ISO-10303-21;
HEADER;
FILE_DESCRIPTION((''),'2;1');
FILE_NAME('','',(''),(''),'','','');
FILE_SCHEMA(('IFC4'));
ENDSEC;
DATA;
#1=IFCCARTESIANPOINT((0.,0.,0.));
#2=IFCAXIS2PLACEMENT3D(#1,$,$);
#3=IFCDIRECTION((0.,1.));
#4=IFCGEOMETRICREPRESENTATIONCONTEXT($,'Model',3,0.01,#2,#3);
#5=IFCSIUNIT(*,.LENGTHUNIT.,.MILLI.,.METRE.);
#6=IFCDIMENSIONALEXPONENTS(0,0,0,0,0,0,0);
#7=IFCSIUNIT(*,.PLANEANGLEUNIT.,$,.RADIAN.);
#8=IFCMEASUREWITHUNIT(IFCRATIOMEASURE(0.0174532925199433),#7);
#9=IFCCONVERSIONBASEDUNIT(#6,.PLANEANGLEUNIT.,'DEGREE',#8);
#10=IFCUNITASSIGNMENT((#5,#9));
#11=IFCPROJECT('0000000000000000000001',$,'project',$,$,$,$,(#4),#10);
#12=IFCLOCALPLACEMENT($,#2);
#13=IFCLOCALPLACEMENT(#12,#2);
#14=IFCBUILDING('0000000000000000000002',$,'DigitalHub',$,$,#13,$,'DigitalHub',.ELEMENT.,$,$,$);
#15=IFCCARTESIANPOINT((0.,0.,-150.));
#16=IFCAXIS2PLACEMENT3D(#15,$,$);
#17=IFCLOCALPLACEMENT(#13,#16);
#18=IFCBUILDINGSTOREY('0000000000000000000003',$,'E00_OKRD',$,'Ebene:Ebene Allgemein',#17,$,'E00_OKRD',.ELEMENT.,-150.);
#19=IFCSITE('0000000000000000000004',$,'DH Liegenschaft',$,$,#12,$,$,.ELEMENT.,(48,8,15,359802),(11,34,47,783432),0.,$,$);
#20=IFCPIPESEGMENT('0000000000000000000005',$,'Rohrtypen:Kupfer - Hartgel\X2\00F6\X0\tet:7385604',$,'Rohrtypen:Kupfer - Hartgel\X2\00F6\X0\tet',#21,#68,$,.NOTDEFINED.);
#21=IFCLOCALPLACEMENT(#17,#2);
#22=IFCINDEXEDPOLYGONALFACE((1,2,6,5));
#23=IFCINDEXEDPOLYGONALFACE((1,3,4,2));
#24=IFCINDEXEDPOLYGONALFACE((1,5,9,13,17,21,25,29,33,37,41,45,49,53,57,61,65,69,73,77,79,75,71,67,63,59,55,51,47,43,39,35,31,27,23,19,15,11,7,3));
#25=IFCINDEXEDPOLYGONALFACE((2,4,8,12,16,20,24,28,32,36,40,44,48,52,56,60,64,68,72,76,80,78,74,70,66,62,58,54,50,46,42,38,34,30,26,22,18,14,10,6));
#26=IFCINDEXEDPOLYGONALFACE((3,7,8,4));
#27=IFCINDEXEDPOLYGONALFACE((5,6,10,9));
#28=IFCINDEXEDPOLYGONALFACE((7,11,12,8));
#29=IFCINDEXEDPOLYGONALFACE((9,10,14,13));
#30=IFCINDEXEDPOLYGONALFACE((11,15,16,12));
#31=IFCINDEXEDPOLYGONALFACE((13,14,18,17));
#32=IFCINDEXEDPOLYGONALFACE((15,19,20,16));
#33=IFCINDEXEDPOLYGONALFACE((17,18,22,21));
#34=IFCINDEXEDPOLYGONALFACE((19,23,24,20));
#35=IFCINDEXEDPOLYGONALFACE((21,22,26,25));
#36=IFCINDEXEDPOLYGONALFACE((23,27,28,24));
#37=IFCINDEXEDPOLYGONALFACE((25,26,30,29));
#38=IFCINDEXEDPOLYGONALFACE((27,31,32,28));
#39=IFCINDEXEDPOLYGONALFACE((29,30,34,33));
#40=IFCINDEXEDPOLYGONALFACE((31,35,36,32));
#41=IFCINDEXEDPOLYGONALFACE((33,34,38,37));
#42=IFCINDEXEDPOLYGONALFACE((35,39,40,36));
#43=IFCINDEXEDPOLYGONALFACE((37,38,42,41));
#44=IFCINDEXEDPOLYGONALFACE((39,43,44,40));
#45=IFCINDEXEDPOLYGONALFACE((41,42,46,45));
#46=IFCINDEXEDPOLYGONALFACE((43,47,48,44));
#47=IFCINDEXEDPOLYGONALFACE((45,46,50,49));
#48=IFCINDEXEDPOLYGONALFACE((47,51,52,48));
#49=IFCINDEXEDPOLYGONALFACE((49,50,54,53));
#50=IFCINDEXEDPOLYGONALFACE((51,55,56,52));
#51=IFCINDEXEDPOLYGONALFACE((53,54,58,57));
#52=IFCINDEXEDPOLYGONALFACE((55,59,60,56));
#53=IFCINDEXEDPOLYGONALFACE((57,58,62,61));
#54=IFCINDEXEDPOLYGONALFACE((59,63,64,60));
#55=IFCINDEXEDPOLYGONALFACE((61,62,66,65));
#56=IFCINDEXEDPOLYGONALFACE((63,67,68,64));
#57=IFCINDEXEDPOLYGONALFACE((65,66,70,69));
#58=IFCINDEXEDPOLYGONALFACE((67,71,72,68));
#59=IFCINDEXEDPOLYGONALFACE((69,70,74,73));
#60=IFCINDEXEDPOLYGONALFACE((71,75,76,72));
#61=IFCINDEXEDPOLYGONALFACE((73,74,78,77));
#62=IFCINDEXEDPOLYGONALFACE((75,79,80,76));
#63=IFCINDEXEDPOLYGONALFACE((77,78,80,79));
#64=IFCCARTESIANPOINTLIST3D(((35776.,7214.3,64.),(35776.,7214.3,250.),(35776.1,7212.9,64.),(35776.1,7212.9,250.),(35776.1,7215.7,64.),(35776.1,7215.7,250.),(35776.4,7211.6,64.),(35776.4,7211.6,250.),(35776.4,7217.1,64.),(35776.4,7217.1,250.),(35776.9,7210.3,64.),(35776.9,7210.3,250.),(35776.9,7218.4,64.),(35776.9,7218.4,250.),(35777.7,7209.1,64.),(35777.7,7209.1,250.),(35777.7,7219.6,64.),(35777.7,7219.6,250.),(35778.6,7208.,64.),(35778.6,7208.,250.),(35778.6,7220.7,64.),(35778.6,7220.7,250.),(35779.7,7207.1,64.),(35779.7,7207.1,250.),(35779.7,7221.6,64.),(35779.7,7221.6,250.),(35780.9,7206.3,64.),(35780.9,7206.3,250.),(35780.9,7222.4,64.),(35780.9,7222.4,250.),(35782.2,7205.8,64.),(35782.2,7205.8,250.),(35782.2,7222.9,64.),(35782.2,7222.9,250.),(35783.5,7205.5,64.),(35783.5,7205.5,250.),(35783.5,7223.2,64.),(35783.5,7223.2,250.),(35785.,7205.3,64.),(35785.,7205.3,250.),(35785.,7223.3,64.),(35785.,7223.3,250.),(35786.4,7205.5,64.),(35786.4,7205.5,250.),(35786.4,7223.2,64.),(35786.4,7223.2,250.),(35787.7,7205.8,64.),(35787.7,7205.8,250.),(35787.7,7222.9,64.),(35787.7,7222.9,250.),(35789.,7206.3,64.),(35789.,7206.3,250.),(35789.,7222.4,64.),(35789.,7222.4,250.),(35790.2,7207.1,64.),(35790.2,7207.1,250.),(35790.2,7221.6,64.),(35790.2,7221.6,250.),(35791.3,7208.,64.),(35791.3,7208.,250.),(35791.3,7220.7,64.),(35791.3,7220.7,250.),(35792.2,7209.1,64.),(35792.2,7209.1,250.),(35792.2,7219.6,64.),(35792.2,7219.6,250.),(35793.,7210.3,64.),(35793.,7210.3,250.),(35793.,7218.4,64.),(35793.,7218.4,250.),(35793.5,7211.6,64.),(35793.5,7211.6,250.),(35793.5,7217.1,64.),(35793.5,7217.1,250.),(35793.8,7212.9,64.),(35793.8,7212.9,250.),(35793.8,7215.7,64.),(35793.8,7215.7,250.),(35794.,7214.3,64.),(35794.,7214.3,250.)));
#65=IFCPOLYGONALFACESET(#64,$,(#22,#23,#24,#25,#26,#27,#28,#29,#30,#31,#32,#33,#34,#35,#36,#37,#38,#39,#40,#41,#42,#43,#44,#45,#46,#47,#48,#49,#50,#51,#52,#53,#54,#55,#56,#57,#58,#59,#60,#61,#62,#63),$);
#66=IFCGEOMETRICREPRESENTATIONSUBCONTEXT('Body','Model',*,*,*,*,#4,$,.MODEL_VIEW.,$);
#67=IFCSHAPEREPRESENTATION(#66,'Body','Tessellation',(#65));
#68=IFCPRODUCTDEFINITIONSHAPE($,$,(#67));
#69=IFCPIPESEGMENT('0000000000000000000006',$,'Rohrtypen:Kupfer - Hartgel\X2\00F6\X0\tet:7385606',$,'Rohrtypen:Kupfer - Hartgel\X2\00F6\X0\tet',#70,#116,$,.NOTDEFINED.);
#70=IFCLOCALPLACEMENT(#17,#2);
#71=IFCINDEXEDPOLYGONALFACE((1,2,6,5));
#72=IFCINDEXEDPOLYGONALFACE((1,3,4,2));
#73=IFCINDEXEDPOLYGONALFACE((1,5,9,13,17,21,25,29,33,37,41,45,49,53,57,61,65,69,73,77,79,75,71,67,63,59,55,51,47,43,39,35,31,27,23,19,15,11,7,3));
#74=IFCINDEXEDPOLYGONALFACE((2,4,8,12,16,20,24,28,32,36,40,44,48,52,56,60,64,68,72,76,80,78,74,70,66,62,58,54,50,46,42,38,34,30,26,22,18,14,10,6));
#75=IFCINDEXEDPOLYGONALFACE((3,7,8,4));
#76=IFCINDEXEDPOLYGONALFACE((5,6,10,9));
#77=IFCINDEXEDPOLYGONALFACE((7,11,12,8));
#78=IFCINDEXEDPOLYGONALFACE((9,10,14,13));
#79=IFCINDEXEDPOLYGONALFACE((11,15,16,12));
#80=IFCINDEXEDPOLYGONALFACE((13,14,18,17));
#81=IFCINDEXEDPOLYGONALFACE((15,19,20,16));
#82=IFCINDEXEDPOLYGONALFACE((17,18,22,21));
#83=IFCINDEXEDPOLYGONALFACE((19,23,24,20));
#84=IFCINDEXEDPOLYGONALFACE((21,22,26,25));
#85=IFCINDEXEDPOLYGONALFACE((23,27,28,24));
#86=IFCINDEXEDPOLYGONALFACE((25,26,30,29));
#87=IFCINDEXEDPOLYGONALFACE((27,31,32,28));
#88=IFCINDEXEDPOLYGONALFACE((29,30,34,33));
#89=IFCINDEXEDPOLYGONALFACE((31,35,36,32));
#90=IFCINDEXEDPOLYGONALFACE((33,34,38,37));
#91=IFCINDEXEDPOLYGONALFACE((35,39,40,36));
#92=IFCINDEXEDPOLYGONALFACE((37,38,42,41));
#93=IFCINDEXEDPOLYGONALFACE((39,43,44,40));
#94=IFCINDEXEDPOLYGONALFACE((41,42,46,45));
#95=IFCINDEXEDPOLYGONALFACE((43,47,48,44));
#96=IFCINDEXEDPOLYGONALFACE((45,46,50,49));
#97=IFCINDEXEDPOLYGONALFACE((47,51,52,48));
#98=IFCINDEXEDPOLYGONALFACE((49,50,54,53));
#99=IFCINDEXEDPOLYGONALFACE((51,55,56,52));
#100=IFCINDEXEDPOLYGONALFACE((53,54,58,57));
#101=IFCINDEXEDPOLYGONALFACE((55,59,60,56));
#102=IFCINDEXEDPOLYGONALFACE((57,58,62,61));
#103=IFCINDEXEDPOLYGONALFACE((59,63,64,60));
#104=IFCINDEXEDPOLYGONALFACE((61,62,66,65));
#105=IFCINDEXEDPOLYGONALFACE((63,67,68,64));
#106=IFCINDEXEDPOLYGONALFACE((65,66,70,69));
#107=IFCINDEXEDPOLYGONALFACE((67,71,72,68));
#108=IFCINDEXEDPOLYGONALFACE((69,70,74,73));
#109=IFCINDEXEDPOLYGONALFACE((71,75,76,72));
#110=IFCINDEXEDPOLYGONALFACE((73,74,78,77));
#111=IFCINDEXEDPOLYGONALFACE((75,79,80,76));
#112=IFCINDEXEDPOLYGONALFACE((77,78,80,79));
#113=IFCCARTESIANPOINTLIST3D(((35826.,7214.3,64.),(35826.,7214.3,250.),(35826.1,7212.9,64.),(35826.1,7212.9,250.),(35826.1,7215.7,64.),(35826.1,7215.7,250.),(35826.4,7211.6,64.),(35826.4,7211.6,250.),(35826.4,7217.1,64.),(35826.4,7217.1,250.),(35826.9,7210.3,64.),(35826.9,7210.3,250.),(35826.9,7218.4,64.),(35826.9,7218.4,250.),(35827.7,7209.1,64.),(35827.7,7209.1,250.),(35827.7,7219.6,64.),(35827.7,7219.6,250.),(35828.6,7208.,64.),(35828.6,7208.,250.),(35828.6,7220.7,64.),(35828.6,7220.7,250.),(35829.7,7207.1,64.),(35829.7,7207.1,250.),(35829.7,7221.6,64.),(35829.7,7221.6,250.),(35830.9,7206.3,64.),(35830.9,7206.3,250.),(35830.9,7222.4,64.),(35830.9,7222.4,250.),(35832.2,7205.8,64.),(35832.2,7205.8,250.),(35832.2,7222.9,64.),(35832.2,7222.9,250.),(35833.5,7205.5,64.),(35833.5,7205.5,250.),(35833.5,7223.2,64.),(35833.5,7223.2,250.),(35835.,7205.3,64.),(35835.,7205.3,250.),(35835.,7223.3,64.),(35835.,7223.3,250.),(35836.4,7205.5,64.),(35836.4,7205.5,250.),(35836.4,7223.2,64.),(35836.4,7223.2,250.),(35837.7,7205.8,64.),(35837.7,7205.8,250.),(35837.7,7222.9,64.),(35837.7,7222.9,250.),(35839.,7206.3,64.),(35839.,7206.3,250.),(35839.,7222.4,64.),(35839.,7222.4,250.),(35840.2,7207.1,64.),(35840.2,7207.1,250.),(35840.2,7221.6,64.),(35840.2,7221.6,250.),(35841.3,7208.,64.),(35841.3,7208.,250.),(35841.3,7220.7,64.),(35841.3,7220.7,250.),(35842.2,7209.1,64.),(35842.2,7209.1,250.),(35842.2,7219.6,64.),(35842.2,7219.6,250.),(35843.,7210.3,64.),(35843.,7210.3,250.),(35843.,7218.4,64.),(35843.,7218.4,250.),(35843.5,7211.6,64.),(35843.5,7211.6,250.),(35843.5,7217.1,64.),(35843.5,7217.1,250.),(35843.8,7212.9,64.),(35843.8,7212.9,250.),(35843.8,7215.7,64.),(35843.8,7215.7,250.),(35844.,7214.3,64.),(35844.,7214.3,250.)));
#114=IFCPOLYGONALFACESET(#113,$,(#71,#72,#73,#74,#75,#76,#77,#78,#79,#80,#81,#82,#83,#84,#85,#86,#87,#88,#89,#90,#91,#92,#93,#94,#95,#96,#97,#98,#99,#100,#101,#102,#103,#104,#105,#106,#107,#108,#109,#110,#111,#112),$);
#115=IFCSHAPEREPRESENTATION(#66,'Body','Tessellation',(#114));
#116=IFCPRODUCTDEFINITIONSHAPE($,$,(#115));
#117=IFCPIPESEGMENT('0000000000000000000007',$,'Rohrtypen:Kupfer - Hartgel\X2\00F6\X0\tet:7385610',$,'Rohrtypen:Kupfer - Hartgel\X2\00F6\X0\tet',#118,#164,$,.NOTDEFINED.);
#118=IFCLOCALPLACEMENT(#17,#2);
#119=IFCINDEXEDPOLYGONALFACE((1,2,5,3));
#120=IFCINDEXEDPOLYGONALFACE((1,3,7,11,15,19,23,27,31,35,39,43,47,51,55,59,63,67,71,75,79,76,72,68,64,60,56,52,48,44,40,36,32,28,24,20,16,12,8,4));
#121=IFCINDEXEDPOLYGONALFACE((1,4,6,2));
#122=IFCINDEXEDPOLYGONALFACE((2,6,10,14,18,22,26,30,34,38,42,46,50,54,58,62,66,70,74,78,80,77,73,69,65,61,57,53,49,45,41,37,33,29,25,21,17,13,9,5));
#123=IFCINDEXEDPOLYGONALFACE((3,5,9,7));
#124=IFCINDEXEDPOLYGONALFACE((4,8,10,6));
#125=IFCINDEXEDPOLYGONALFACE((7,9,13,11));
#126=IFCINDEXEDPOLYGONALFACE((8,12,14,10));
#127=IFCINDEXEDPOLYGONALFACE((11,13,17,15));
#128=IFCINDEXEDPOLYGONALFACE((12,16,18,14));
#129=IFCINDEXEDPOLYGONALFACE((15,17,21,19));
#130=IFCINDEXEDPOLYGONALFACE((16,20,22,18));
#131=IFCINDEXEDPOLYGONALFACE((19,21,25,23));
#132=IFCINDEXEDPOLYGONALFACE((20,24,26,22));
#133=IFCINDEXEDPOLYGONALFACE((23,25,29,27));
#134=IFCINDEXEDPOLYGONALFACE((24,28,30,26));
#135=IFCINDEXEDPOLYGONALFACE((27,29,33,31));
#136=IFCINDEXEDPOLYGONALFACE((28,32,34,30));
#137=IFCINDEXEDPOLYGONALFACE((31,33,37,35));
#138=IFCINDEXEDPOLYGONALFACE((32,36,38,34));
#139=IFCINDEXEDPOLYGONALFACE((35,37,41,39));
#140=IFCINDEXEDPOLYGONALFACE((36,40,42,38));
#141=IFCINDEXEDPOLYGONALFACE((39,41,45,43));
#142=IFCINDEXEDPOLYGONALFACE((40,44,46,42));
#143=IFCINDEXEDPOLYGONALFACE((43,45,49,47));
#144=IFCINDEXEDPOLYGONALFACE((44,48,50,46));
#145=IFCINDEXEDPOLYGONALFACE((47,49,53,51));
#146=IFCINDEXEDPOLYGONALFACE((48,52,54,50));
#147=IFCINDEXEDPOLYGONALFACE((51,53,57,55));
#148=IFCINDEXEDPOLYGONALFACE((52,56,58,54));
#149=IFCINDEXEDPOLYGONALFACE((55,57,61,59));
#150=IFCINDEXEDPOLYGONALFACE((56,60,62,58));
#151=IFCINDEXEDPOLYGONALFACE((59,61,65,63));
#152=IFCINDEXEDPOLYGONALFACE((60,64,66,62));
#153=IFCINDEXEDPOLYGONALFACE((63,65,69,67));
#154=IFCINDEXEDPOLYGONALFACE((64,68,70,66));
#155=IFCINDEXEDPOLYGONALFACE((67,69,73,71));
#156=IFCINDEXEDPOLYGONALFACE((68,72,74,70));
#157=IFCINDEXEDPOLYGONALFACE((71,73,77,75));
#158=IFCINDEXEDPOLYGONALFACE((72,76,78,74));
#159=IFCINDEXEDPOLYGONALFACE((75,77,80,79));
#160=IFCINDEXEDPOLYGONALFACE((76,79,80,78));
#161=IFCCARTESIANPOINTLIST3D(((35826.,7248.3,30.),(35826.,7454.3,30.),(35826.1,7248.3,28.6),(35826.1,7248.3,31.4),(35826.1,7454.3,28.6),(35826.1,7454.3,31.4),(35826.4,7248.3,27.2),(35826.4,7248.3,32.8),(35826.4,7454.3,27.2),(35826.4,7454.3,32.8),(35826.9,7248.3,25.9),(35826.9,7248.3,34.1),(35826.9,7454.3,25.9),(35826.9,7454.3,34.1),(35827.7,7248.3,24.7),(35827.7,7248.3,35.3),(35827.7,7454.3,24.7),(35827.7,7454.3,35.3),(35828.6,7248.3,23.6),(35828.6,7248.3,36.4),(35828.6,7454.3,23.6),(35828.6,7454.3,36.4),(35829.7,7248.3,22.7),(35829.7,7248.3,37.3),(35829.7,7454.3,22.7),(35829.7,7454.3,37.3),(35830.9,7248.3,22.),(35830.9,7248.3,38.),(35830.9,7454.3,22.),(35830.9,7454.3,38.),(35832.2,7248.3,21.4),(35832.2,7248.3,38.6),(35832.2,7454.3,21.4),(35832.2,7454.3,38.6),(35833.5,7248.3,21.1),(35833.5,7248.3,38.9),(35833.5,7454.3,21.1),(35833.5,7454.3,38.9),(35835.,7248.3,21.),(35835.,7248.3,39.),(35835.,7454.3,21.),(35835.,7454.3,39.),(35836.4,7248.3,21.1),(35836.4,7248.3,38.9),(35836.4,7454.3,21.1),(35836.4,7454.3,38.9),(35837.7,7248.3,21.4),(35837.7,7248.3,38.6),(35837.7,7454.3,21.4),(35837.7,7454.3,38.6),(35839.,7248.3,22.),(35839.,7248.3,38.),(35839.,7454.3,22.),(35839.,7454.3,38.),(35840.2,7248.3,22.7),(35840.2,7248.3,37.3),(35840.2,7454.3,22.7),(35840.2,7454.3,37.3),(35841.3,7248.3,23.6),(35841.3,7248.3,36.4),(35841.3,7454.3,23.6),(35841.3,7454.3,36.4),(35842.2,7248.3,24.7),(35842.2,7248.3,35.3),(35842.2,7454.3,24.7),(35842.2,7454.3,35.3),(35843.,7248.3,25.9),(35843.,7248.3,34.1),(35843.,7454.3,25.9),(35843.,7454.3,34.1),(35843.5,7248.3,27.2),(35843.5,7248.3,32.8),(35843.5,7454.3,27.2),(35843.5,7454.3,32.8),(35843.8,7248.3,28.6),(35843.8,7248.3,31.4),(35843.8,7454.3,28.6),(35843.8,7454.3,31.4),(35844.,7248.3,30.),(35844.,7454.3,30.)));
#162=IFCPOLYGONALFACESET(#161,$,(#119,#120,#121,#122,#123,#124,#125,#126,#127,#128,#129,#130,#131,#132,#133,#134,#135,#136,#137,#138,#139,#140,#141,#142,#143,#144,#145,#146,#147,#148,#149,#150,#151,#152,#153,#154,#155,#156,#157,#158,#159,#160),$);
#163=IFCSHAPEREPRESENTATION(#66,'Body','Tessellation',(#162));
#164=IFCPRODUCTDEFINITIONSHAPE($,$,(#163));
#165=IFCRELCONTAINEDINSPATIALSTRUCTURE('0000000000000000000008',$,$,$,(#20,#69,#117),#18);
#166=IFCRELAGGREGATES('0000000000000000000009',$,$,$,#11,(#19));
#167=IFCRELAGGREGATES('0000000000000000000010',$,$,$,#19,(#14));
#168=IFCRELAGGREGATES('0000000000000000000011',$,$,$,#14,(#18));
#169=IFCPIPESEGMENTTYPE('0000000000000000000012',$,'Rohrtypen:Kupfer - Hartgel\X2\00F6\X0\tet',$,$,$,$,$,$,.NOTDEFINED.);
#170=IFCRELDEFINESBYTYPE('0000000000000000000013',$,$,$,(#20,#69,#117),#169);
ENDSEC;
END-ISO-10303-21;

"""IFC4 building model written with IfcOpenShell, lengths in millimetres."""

from ifc_helpers import new_model, entity, si_unit, converted_unit, direction, frame, origin, place, context, subcontext, project, spatial, indexed_curve, outline, extrude, type_object, element, save


model = new_model("IFC4")

# Units and contexts
model_context = context("Model", 3, precision=0.01, world=origin(), true_north=direction((0.0, 1.0)))
body_context = subcontext(model_context, "Body", "Model", "MODEL_VIEW")
ifc_project = project(units=[si_unit("LENGTHUNIT", "METRE", prefix="MILLI"), converted_unit("PLANEANGLEUNIT", "DEGREE", entity("IfcRatioMeasure", 0.0174532925199433), si_unit("PLANEANGLEUNIT", "RADIAN"), dimensions=[0, 0, 0, 0, 0, 0, 0])], contexts=[model_context])

# Site, building, storey
site_placement = place(None, origin())
site = spatial("IfcSite", under=ifc_project, at=site_placement, Name="DH Liegenschaft", CompositionType="ELEMENT", RefLatitude=(48, 8, 15, 359802), RefLongitude=(11, 34, 47, 783432), RefElevation=0.0)
building_placement = place(site_placement, origin())
building = spatial("IfcBuilding", under=site, at=building_placement, Name="DigitalHub", LongName="DigitalHub", CompositionType="ELEMENT")
storey_placement = place(building_placement, frame((0.0, 0.0, -150.0)))
storey = spatial("IfcBuildingStorey", under=building, at=storey_placement, Name="E00_OKRD", ObjectType="Ebene:Ebene Allgemein", LongName="E00_OKRD", CompositionType="ELEMENT", Elevation=-150.0)

# Pipe segments
pipe_segment_type = type_object("IfcPipeSegmentType", Name="Rohrtypen:Kupfer - Hartgelötet", PredefinedType="NOTDEFINED")
pipe_segment_1_placement = place(storey_placement, frame((35774.4, 7203.7, 64.0)))
element("IfcPipeSegment", 1, at=pipe_segment_1_placement, inside=storey, type_object=pipe_segment_type, Name="Rohrtypen:Kupfer - Hartgelötet:7385604", ObjectType="Rohrtypen:Kupfer - Hartgelötet", PredefinedType="NOTDEFINED", context=body_context, shape_type="SweptSolid", body=[
    extrude(outline(indexed_curve([(9.0, 0.0), (8.9, 1.4), (8.6, 2.8), (8.0, 4.1), (7.3, 5.3), (6.4, 6.4), (5.3, 7.3), (4.1, 8.0), (2.8, 8.6), (1.4, 8.9), (0.0, 9.0), (-1.4, 8.9), (-2.8, 8.6), (-4.1, 8.0), (-5.3, 7.3), (-6.4, 6.4), (-7.3, 5.3), (-8.0, 4.1), (-8.6, 2.8), (-8.9, 1.4), (-9.0, 0.0), (-8.9, -1.4), (-8.6, -2.8), (-8.0, -4.1), (-7.3, -5.3), (-6.4, -6.4), (-5.3, -7.3), (-4.1, -8.0), (-2.8, -8.6), (-1.4, -8.9), (0.0, -9.0), (1.4, -8.9), (2.8, -8.6), (4.1, -8.0), (5.3, -7.3), (6.4, -6.4), (7.3, -5.3), (8.0, -4.1), (8.6, -2.8), (8.9, -1.4), (9.0, 0.0)], self_intersect=False)), frame((10.6, 10.6, 0.0)), (0.0, 0.0, 1.0), 186.0),
])
pipe_segment_2_placement = place(storey_placement, frame((35824.4, 7203.7, 64.0)))
element("IfcPipeSegment", 2, at=pipe_segment_2_placement, inside=storey, type_object=pipe_segment_type, Name="Rohrtypen:Kupfer - Hartgelötet:7385606", ObjectType="Rohrtypen:Kupfer - Hartgelötet", PredefinedType="NOTDEFINED", context=body_context, shape_type="SweptSolid", body=[
    extrude(outline(indexed_curve([(9.0, 0.0), (8.9, 1.4), (8.6, 2.8), (8.0, 4.1), (7.3, 5.3), (6.4, 6.4), (5.3, 7.3), (4.1, 8.0), (2.8, 8.6), (1.4, 8.9), (0.0, 9.0), (-1.4, 8.9), (-2.8, 8.6), (-4.1, 8.0), (-5.3, 7.3), (-6.4, 6.4), (-7.3, 5.3), (-8.0, 4.1), (-8.6, 2.8), (-8.9, 1.4), (-9.0, 0.0), (-8.9, -1.4), (-8.6, -2.8), (-8.0, -4.1), (-7.3, -5.3), (-6.4, -6.4), (-5.3, -7.3), (-4.1, -8.0), (-2.8, -8.6), (-1.4, -8.9), (0.0, -9.0), (1.4, -8.9), (2.8, -8.6), (4.1, -8.0), (5.3, -7.3), (6.4, -6.4), (7.3, -5.3), (8.0, -4.1), (8.6, -2.8), (8.9, -1.4), (9.0, 0.0)], self_intersect=False)), frame((10.6, 10.6, 0.0)), (0.0, 0.0, 1.0), 186.0),
])
pipe_segment_3_placement = place(storey_placement, frame((35824.4, 7248.3, 19.4)))
element("IfcPipeSegment", 3, at=pipe_segment_3_placement, inside=storey, type_object=pipe_segment_type, Name="Rohrtypen:Kupfer - Hartgelötet:7385610", ObjectType="Rohrtypen:Kupfer - Hartgelötet", PredefinedType="NOTDEFINED", context=body_context, shape_type="SweptSolid", body=[
    extrude(outline(indexed_curve([(9.0, 0.0), (8.9, 1.4), (8.6, 2.8), (8.0, 4.1), (7.3, 5.3), (6.4, 6.4), (5.3, 7.3), (4.1, 8.0), (2.8, 8.6), (1.4, 8.9), (0.0, 9.0), (-1.4, 8.9), (-2.8, 8.6), (-4.1, 8.0), (-5.3, 7.3), (-6.4, 6.4), (-7.3, 5.3), (-8.0, 4.1), (-8.6, 2.8), (-8.9, 1.4), (-9.0, 0.0), (-8.9, -1.4), (-8.6, -2.8), (-8.0, -4.1), (-7.3, -5.3), (-6.4, -6.4), (-5.3, -7.3), (-4.1, -8.0), (-2.8, -8.6), (-1.4, -8.9), (0.0, -9.0), (1.4, -8.9), (2.8, -8.6), (4.1, -8.0), (5.3, -7.3), (6.4, -6.4), (7.3, -5.3), (8.0, -4.1), (8.6, -2.8), (8.9, -1.4), (9.0, 0.0)], self_intersect=False)), frame((10.6, 0.0, 10.6), z_axis=(0.0, 1.0, 0.0), x_axis=(1.0, 0.0, 0.0)), (0.0, 0.0, 1.0), 205.9),
])

save(model, "model.ifc")
